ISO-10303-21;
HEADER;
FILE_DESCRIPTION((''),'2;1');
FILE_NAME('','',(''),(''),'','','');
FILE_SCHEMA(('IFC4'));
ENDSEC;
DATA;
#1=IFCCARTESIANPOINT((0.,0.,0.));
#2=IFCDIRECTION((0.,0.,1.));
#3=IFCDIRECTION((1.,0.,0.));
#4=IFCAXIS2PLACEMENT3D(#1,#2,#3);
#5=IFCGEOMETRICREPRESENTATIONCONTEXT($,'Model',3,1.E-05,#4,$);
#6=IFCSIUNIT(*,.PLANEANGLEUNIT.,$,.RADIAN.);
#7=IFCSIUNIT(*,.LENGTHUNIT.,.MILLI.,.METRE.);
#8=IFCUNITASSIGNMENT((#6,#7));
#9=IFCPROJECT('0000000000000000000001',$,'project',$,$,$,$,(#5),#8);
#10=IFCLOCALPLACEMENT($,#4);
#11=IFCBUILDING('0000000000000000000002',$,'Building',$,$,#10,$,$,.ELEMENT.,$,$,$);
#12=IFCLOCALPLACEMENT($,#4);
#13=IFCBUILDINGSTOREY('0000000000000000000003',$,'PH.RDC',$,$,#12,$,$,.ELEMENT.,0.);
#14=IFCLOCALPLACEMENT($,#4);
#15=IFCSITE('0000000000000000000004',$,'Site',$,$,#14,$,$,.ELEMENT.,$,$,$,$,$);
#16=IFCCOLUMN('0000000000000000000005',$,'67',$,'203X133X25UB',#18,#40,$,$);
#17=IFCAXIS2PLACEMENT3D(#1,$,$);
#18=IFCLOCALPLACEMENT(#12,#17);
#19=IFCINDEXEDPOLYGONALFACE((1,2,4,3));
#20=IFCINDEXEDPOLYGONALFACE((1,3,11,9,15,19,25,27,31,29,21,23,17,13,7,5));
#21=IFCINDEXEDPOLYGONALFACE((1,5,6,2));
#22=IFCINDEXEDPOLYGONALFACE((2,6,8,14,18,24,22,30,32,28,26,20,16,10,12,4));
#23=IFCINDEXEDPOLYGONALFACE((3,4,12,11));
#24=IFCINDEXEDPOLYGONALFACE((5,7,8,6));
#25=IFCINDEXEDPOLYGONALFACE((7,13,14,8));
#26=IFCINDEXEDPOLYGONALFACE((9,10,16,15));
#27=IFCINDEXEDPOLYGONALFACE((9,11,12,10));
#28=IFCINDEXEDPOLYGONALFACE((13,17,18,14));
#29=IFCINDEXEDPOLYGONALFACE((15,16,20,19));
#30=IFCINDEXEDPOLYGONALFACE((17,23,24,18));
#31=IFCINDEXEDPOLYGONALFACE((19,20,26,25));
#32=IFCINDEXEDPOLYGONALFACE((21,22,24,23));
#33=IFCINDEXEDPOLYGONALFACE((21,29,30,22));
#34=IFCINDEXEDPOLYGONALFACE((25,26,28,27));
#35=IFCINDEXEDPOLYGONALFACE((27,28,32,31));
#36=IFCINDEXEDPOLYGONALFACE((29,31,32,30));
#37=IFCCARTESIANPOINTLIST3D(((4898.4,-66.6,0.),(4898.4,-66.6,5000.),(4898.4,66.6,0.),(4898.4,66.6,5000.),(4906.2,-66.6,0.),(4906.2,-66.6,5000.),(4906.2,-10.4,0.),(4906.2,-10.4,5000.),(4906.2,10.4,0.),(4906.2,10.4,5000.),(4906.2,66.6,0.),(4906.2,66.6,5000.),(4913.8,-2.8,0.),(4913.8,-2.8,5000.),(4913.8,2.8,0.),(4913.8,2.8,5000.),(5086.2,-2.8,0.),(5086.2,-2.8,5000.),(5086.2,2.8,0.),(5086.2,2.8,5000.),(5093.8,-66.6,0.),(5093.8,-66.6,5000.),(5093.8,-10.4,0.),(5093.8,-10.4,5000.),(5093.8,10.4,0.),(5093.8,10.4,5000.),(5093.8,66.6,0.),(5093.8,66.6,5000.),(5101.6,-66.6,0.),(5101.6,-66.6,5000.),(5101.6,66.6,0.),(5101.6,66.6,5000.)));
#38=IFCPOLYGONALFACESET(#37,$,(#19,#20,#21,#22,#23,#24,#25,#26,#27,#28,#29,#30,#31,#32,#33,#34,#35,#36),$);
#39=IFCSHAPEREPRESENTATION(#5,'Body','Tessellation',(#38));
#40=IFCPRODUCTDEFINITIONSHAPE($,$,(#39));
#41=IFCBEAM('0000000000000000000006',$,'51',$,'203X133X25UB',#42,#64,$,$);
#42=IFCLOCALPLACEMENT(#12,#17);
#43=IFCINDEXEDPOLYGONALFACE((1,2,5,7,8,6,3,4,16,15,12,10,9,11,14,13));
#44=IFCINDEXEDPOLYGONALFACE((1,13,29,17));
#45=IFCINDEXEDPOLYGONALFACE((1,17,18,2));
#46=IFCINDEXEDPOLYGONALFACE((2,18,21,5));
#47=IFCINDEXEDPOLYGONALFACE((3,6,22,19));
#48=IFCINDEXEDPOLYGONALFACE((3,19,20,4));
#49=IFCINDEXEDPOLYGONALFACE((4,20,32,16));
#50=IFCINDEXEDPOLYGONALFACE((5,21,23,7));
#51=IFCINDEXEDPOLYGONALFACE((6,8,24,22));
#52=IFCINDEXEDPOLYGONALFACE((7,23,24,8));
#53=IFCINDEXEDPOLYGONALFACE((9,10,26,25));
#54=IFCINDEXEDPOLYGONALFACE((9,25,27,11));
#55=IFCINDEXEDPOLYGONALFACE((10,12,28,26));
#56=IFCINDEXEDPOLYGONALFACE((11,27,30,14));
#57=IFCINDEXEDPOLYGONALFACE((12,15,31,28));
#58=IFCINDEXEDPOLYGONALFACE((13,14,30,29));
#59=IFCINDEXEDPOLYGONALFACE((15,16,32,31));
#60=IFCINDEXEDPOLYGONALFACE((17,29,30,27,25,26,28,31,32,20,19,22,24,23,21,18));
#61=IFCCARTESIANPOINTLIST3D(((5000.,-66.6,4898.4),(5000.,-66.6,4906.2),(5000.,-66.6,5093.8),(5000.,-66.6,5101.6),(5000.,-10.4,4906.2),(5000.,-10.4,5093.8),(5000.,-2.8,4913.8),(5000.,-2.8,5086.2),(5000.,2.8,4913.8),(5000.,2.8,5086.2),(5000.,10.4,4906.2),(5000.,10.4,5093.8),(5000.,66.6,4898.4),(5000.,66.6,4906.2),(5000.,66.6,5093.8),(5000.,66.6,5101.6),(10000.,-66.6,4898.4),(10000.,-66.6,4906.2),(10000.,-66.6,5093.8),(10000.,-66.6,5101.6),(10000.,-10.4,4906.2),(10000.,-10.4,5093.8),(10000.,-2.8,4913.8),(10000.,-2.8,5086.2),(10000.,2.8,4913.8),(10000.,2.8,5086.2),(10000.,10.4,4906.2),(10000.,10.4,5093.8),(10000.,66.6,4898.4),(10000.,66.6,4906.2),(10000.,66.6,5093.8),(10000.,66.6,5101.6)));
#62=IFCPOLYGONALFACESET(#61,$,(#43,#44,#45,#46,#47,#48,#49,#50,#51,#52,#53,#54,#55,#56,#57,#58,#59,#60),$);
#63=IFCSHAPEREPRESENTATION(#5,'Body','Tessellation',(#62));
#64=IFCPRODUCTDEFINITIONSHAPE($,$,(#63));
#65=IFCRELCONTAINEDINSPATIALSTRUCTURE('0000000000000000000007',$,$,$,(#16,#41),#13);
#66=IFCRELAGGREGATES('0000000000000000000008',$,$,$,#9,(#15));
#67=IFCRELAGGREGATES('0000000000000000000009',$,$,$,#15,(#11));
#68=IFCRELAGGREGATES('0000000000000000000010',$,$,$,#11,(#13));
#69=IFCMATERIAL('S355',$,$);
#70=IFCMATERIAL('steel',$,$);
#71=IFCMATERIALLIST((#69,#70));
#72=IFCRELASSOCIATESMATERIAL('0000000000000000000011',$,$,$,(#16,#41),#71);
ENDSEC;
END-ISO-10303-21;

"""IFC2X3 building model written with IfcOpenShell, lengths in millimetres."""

from ifc_helpers import new_model, si_unit, frame, origin_with_axes, place, context, project, spatial, polyline, outline, extrude, material, material_list, element, save


model = new_model("IFC2X3")

# Units and contexts
model_context = context("Model", 3, precision=1e-05, world=origin_with_axes())
ifc_project = project(units=[si_unit("PLANEANGLEUNIT", "RADIAN"), si_unit("LENGTHUNIT", "METRE", prefix="MILLI")], contexts=[model_context])

# Site, building, storey
site_placement = place(None, origin_with_axes())
site = spatial("IfcSite", under=ifc_project, at=site_placement, Name="Site", CompositionType="ELEMENT")
building_placement = place(None, origin_with_axes())
building = spatial("IfcBuilding", under=site, at=building_placement, Name="Building", CompositionType="ELEMENT")
storey_placement = place(None, origin_with_axes())
storey = spatial("IfcBuildingStorey", under=building, at=storey_placement, Name="PH.RDC", CompositionType="ELEMENT", Elevation=0.0)

# Column
ifc_material_1 = material(Name="S355")
ifc_material_2 = material(Name="steel")
ifc_material_list = material_list([ifc_material_1, ifc_material_2])
column_placement = place(building_placement, frame((5000.0, 0.0, 0.0), z_axis=(1.0, 0.0, 0.0), x_axis=(0.0, 0.0, 1.0)))
element("IfcColumn", 1, at=column_placement, inside=storey, material=ifc_material_list, Name="67", ObjectType="203X133X25UB", context=model_context, shape_type="SweptSolid", body=[
    extrude(outline(polyline([(-66.6, 101.6), (66.6, 101.6), (66.6, 93.8), (10.4, 93.8), (2.9, 86.2), (2.9, -86.2), (10.4, -93.8), (66.6, -93.8), (66.6, -101.6), (-66.6, -101.6), (-66.6, -93.8), (-10.4, -93.8), (-2.9, -86.2), (-2.9, 86.2), (-10.4, 93.8), (-66.6, 93.8), (-66.6, 101.6)])), frame((0.0, 0.0, 0.0), z_axis=(1.0, 0.0, 0.0), x_axis=(0.0, 1.0, 0.0)), (0.0, 0.0, 1.0), 5000.0),
])

# Beam
beam_placement = place(building_placement, frame((5000.0, 0.0, 5000.0), z_axis=(0.0, 0.0, 1.0), x_axis=(1.0, 0.0, 0.0)))
element("IfcBeam", 2, at=beam_placement, inside=storey, material=ifc_material_list, Name="51", ObjectType="203X133X25UB", context=model_context, shape_type="SweptSolid", body=[
    extrude(outline(polyline([(-66.6, 101.6), (66.6, 101.6), (66.6, 93.8), (10.4, 93.8), (2.9, 86.2), (2.9, -86.2), (10.4, -93.8), (66.6, -93.8), (66.6, -101.6), (-66.6, -101.6), (-66.6, -93.8), (-10.4, -93.8), (-2.9, -86.2), (-2.9, 86.2), (-10.4, 93.8), (-66.6, 93.8), (-66.6, 101.6)])), frame((0.0, 0.0, 0.0), z_axis=(1.0, 0.0, 0.0), x_axis=(0.0, 1.0, 0.0)), (0.0, 0.0, 1.0), 5000.0),
])

save(model, "model.ifc")
